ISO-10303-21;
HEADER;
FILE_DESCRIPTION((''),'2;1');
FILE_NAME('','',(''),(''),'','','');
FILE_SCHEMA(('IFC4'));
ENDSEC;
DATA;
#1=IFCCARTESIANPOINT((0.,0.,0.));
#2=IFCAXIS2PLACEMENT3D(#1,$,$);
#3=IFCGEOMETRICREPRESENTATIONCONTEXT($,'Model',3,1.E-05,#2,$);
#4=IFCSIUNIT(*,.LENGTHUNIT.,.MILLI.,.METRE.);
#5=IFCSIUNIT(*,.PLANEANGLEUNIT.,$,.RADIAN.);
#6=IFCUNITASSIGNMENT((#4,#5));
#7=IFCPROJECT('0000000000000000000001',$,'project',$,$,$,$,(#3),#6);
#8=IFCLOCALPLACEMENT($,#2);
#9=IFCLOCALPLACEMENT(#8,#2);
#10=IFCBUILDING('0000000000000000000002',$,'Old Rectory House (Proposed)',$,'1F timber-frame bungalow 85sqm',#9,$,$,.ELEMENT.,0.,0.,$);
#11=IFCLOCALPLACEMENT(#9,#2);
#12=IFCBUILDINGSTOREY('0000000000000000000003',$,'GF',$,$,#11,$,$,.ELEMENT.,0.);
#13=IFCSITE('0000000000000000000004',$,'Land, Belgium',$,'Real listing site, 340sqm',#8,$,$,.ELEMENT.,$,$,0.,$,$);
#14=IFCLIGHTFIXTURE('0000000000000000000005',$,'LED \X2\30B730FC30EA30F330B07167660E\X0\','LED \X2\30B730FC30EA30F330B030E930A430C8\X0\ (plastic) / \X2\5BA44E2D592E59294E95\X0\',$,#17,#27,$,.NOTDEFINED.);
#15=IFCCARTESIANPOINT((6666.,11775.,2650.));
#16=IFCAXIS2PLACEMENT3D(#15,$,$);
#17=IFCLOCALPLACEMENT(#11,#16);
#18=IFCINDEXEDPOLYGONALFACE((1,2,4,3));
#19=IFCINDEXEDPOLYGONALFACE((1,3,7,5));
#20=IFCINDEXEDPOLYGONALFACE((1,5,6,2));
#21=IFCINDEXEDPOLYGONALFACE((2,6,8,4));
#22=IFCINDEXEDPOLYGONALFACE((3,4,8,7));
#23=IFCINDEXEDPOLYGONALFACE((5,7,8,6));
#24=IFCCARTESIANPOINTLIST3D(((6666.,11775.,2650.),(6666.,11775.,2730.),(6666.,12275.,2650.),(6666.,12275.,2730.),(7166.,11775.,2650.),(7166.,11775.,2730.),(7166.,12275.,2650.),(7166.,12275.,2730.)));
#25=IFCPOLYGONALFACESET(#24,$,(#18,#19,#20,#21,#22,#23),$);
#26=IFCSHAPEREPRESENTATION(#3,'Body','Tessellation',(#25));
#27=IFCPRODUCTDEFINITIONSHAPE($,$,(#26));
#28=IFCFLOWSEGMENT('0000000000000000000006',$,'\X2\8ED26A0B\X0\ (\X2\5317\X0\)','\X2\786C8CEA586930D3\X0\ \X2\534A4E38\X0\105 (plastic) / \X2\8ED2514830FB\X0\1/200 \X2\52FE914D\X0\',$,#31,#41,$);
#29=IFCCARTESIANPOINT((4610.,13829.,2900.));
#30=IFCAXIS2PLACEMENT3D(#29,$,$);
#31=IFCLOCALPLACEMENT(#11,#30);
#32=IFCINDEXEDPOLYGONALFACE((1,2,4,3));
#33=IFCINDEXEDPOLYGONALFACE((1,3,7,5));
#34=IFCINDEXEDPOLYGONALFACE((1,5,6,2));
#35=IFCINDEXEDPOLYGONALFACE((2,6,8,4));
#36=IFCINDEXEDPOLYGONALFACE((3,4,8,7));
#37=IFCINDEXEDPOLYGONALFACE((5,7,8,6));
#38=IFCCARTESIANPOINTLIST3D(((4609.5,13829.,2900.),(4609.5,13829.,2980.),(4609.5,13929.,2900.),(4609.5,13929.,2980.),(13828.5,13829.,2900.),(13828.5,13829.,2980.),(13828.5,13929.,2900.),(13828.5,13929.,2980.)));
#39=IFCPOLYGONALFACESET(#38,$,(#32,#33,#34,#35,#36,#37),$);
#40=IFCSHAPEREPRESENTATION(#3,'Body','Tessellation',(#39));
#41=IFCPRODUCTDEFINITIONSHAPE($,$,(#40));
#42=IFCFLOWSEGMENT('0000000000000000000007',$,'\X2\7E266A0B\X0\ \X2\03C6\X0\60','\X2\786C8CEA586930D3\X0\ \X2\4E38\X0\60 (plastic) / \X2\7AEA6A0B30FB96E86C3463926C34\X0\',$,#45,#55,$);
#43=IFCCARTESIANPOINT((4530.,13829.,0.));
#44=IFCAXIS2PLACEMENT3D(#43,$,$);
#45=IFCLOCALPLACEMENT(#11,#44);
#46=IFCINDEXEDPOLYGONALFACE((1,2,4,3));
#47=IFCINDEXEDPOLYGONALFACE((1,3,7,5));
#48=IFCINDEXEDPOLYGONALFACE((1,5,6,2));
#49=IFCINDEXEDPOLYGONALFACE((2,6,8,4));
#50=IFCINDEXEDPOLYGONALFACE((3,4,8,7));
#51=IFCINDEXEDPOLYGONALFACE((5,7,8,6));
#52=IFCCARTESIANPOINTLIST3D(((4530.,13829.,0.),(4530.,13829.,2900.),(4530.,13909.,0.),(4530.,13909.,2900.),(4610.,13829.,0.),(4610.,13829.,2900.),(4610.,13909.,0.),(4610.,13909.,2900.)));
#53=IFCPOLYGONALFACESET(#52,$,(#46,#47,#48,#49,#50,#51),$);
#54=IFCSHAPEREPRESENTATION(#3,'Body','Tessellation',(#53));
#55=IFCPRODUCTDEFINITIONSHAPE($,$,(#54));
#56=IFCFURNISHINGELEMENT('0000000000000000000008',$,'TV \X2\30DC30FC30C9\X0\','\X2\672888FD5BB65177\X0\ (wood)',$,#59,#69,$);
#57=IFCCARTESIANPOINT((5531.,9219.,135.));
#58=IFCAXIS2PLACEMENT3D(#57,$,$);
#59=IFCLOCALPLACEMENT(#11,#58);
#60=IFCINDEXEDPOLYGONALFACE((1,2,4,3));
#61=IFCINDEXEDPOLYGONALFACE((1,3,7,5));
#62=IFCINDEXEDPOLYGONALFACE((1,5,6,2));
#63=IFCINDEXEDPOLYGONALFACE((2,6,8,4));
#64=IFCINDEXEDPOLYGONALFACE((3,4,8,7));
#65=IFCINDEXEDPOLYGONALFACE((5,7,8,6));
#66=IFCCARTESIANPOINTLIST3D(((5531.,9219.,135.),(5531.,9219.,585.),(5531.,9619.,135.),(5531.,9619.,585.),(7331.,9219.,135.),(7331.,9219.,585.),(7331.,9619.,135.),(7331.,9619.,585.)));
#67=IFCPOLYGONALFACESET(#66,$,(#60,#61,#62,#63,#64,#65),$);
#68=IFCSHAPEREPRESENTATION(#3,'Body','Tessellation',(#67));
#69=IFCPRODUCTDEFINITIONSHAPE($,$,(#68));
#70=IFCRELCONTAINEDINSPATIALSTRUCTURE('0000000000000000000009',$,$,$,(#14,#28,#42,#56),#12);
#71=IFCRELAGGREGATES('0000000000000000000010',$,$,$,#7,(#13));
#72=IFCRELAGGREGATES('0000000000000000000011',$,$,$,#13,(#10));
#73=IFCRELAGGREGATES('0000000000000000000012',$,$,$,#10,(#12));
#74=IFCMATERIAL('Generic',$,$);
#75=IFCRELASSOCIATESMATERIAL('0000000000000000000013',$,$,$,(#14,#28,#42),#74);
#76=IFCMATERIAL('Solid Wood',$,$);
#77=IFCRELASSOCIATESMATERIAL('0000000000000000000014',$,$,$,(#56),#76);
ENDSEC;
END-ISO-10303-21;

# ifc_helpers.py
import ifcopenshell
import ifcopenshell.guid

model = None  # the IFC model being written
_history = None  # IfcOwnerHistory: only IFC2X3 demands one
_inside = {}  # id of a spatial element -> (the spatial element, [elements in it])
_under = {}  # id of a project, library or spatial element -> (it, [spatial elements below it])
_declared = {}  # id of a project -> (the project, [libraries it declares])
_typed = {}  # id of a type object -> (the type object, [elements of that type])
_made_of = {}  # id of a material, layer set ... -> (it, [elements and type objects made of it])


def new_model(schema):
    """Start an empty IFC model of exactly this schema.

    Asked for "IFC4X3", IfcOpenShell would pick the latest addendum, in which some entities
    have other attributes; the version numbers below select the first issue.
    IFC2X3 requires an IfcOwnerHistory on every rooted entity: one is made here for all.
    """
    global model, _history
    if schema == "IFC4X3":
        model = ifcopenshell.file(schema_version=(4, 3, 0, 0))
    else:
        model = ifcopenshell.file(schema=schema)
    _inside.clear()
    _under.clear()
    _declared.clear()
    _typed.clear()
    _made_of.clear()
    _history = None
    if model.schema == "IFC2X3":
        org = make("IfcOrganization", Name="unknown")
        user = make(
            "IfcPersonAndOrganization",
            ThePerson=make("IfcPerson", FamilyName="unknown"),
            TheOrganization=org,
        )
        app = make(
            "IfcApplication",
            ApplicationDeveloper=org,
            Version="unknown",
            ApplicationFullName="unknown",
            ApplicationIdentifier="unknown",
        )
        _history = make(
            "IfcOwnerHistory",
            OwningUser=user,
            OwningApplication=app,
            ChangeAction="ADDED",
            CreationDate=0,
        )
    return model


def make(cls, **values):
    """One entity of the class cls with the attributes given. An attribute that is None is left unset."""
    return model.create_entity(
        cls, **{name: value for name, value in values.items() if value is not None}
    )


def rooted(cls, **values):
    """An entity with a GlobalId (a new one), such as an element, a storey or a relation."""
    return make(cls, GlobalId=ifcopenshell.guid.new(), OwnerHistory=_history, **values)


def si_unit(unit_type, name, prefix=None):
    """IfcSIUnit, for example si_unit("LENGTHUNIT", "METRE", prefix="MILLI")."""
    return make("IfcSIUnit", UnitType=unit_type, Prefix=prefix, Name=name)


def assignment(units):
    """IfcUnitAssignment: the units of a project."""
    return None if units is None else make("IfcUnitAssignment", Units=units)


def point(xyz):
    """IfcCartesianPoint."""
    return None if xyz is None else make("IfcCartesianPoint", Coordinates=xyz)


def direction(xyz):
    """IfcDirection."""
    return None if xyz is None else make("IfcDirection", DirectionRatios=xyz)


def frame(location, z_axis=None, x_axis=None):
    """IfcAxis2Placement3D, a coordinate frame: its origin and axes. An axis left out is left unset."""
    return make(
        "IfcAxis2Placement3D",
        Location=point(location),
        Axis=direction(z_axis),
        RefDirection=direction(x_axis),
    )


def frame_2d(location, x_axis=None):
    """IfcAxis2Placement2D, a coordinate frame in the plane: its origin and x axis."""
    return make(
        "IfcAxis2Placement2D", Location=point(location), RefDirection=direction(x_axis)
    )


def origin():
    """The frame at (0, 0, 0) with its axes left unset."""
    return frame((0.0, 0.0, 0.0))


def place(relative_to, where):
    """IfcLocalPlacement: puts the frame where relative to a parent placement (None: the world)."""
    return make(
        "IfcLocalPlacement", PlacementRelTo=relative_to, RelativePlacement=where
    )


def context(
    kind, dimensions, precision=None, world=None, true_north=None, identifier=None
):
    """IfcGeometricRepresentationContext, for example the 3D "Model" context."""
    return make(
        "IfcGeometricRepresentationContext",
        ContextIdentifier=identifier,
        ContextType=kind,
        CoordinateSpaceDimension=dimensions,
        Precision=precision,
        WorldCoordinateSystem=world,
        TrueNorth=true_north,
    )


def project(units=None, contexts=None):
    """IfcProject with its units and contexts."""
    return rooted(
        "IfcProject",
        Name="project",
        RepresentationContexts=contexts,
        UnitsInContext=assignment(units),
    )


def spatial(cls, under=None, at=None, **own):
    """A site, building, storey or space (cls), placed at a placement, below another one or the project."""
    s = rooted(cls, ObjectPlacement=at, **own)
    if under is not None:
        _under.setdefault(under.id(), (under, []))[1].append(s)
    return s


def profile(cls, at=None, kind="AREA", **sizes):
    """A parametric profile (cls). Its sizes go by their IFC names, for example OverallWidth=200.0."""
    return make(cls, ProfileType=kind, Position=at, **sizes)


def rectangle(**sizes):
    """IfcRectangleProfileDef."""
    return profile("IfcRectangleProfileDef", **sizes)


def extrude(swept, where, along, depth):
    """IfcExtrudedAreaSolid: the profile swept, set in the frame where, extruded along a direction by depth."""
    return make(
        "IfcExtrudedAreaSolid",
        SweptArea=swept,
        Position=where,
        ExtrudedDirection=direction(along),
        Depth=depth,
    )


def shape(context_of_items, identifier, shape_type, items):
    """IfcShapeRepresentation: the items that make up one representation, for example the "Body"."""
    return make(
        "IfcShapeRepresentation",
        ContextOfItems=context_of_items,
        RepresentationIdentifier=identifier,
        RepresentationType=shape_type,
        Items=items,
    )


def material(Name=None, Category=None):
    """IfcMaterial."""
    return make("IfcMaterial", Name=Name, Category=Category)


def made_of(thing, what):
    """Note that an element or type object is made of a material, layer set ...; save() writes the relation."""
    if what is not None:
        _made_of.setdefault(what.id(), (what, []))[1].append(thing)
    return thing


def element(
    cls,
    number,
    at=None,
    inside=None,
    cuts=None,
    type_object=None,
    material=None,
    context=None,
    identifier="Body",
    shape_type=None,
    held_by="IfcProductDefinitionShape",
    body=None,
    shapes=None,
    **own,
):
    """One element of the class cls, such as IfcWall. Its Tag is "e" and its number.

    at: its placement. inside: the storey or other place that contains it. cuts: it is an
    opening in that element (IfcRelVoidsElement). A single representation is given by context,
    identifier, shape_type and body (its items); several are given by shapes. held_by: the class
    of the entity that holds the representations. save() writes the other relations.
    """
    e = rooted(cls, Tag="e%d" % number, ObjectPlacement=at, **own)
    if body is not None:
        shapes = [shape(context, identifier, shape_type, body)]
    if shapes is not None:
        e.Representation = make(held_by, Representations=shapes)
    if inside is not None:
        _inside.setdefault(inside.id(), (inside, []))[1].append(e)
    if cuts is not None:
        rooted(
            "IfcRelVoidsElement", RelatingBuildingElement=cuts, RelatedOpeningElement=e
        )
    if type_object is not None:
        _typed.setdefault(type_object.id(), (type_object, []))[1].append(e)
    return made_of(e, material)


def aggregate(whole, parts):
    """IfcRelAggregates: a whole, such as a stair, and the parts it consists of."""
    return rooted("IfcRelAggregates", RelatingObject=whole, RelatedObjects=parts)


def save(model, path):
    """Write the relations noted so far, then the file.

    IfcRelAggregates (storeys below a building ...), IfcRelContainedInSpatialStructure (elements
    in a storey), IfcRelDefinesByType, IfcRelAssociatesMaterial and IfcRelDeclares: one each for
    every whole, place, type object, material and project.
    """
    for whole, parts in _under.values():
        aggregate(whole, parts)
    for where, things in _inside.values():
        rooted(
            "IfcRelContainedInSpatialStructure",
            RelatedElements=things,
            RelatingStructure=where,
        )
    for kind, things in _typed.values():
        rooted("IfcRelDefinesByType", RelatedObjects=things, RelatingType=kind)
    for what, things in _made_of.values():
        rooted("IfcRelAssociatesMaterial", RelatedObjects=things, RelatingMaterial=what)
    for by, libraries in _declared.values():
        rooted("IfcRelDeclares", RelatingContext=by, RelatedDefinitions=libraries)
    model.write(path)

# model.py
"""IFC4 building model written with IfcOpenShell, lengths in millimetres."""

from ifc_helpers import new_model, si_unit, frame, frame_2d, origin, place, context, project, spatial, rectangle, extrude, material, element, save


model = new_model("IFC4")

# Units and contexts
model_context = context("Model", 3, precision=1e-05, world=origin())
ifc_project = project(units=[si_unit("LENGTHUNIT", "METRE", prefix="MILLI"), si_unit("PLANEANGLEUNIT", "RADIAN")], contexts=[model_context])

# Site, building, storey
site_placement = place(None, origin())
site = spatial("IfcSite", under=ifc_project, at=site_placement, Name="Land, Belgium", ObjectType="Real listing site, 340sqm", CompositionType="ELEMENT", RefElevation=0.0)
building_placement = place(site_placement, origin())
building = spatial("IfcBuilding", under=site, at=building_placement, Name="Old Rectory House (Proposed)", ObjectType="1F timber-frame bungalow 85sqm", CompositionType="ELEMENT", ElevationOfRefHeight=0.0, ElevationOfTerrain=0.0)
storey_placement = place(building_placement, origin())
storey = spatial("IfcBuildingStorey", under=building, at=storey_placement, Name="GF", CompositionType="ELEMENT", Elevation=0.0)

# Shared definitions
ifc_material_1 = material(Name="Solid Wood")

# Shared definitions
ifc_material_2 = material(Name="Generic")

# Light fixture
light_fixture_placement = place(storey_placement, frame((6666.0, 11775.0, 2650.0)))
element("IfcLightFixture", 1, at=light_fixture_placement, inside=storey, material=ifc_material_2, Name="LED シーリング照明", Description="LED シーリングライト (plastic) / 室中央天井", PredefinedType="NOTDEFINED", context=model_context, shape_type="SweptSolid", body=[
    extrude(rectangle(XDim=500.0, YDim=500.0, at=frame_2d((250.0, 250.0))), frame((6666.0, 11775.0, 2650.0)), (0.0, 0.0, 1.0), 80.0),
])

# Flow segments
flow_segment_1_placement = place(storey_placement, frame((4610.0, 13829.0, 2900.0)))
element("IfcFlowSegment", 2, at=flow_segment_1_placement, inside=storey, material=ifc_material_2, Name="軒樋 (北)", Description="硬質塩ビ 半丸105 (plastic) / 軒先・1/200 勾配", context=model_context, shape_type="SweptSolid", body=[
    extrude(rectangle(XDim=9219.0, YDim=100.0, at=frame_2d((4609.0, 50.0))), frame((4610.0, 13829.0, 2900.0)), (0.0, 0.0, 1.0), 80.0),
])
flow_segment_2_placement = place(storey_placement, frame((4530.0, 13829.0, 0.0)))
element("IfcFlowSegment", 3, at=flow_segment_2_placement, inside=storey, material=ifc_material_2, Name="縦樋 φ60", Description="硬質塩ビ 丸60 (plastic) / 竪樋・雨水排水", context=model_context, shape_type="SweptSolid", body=[
    extrude(rectangle(XDim=80.0, YDim=80.0, at=frame_2d((40.0, 40.0))), frame((4530.0, 13829.0, 0.0)), (0.0, 0.0, 1.0), 2900.0),
])

# Furnishing element
furnishing_placement = place(storey_placement, frame((5531.0, 9219.0, 135.0)))
element("IfcFurnishingElement", 4, at=furnishing_placement, inside=storey, material=ifc_material_1, Name="TV ボード", Description="木製家具 (wood)", context=model_context, shape_type="SweptSolid", body=[
    extrude(rectangle(XDim=1800.0, YDim=400.0, at=frame_2d((900.0, 200.0))), frame((5531.0, 9219.0, 135.0)), (0.0, 0.0, 1.0), 450.0),
])

save(model, "model.ifc")
